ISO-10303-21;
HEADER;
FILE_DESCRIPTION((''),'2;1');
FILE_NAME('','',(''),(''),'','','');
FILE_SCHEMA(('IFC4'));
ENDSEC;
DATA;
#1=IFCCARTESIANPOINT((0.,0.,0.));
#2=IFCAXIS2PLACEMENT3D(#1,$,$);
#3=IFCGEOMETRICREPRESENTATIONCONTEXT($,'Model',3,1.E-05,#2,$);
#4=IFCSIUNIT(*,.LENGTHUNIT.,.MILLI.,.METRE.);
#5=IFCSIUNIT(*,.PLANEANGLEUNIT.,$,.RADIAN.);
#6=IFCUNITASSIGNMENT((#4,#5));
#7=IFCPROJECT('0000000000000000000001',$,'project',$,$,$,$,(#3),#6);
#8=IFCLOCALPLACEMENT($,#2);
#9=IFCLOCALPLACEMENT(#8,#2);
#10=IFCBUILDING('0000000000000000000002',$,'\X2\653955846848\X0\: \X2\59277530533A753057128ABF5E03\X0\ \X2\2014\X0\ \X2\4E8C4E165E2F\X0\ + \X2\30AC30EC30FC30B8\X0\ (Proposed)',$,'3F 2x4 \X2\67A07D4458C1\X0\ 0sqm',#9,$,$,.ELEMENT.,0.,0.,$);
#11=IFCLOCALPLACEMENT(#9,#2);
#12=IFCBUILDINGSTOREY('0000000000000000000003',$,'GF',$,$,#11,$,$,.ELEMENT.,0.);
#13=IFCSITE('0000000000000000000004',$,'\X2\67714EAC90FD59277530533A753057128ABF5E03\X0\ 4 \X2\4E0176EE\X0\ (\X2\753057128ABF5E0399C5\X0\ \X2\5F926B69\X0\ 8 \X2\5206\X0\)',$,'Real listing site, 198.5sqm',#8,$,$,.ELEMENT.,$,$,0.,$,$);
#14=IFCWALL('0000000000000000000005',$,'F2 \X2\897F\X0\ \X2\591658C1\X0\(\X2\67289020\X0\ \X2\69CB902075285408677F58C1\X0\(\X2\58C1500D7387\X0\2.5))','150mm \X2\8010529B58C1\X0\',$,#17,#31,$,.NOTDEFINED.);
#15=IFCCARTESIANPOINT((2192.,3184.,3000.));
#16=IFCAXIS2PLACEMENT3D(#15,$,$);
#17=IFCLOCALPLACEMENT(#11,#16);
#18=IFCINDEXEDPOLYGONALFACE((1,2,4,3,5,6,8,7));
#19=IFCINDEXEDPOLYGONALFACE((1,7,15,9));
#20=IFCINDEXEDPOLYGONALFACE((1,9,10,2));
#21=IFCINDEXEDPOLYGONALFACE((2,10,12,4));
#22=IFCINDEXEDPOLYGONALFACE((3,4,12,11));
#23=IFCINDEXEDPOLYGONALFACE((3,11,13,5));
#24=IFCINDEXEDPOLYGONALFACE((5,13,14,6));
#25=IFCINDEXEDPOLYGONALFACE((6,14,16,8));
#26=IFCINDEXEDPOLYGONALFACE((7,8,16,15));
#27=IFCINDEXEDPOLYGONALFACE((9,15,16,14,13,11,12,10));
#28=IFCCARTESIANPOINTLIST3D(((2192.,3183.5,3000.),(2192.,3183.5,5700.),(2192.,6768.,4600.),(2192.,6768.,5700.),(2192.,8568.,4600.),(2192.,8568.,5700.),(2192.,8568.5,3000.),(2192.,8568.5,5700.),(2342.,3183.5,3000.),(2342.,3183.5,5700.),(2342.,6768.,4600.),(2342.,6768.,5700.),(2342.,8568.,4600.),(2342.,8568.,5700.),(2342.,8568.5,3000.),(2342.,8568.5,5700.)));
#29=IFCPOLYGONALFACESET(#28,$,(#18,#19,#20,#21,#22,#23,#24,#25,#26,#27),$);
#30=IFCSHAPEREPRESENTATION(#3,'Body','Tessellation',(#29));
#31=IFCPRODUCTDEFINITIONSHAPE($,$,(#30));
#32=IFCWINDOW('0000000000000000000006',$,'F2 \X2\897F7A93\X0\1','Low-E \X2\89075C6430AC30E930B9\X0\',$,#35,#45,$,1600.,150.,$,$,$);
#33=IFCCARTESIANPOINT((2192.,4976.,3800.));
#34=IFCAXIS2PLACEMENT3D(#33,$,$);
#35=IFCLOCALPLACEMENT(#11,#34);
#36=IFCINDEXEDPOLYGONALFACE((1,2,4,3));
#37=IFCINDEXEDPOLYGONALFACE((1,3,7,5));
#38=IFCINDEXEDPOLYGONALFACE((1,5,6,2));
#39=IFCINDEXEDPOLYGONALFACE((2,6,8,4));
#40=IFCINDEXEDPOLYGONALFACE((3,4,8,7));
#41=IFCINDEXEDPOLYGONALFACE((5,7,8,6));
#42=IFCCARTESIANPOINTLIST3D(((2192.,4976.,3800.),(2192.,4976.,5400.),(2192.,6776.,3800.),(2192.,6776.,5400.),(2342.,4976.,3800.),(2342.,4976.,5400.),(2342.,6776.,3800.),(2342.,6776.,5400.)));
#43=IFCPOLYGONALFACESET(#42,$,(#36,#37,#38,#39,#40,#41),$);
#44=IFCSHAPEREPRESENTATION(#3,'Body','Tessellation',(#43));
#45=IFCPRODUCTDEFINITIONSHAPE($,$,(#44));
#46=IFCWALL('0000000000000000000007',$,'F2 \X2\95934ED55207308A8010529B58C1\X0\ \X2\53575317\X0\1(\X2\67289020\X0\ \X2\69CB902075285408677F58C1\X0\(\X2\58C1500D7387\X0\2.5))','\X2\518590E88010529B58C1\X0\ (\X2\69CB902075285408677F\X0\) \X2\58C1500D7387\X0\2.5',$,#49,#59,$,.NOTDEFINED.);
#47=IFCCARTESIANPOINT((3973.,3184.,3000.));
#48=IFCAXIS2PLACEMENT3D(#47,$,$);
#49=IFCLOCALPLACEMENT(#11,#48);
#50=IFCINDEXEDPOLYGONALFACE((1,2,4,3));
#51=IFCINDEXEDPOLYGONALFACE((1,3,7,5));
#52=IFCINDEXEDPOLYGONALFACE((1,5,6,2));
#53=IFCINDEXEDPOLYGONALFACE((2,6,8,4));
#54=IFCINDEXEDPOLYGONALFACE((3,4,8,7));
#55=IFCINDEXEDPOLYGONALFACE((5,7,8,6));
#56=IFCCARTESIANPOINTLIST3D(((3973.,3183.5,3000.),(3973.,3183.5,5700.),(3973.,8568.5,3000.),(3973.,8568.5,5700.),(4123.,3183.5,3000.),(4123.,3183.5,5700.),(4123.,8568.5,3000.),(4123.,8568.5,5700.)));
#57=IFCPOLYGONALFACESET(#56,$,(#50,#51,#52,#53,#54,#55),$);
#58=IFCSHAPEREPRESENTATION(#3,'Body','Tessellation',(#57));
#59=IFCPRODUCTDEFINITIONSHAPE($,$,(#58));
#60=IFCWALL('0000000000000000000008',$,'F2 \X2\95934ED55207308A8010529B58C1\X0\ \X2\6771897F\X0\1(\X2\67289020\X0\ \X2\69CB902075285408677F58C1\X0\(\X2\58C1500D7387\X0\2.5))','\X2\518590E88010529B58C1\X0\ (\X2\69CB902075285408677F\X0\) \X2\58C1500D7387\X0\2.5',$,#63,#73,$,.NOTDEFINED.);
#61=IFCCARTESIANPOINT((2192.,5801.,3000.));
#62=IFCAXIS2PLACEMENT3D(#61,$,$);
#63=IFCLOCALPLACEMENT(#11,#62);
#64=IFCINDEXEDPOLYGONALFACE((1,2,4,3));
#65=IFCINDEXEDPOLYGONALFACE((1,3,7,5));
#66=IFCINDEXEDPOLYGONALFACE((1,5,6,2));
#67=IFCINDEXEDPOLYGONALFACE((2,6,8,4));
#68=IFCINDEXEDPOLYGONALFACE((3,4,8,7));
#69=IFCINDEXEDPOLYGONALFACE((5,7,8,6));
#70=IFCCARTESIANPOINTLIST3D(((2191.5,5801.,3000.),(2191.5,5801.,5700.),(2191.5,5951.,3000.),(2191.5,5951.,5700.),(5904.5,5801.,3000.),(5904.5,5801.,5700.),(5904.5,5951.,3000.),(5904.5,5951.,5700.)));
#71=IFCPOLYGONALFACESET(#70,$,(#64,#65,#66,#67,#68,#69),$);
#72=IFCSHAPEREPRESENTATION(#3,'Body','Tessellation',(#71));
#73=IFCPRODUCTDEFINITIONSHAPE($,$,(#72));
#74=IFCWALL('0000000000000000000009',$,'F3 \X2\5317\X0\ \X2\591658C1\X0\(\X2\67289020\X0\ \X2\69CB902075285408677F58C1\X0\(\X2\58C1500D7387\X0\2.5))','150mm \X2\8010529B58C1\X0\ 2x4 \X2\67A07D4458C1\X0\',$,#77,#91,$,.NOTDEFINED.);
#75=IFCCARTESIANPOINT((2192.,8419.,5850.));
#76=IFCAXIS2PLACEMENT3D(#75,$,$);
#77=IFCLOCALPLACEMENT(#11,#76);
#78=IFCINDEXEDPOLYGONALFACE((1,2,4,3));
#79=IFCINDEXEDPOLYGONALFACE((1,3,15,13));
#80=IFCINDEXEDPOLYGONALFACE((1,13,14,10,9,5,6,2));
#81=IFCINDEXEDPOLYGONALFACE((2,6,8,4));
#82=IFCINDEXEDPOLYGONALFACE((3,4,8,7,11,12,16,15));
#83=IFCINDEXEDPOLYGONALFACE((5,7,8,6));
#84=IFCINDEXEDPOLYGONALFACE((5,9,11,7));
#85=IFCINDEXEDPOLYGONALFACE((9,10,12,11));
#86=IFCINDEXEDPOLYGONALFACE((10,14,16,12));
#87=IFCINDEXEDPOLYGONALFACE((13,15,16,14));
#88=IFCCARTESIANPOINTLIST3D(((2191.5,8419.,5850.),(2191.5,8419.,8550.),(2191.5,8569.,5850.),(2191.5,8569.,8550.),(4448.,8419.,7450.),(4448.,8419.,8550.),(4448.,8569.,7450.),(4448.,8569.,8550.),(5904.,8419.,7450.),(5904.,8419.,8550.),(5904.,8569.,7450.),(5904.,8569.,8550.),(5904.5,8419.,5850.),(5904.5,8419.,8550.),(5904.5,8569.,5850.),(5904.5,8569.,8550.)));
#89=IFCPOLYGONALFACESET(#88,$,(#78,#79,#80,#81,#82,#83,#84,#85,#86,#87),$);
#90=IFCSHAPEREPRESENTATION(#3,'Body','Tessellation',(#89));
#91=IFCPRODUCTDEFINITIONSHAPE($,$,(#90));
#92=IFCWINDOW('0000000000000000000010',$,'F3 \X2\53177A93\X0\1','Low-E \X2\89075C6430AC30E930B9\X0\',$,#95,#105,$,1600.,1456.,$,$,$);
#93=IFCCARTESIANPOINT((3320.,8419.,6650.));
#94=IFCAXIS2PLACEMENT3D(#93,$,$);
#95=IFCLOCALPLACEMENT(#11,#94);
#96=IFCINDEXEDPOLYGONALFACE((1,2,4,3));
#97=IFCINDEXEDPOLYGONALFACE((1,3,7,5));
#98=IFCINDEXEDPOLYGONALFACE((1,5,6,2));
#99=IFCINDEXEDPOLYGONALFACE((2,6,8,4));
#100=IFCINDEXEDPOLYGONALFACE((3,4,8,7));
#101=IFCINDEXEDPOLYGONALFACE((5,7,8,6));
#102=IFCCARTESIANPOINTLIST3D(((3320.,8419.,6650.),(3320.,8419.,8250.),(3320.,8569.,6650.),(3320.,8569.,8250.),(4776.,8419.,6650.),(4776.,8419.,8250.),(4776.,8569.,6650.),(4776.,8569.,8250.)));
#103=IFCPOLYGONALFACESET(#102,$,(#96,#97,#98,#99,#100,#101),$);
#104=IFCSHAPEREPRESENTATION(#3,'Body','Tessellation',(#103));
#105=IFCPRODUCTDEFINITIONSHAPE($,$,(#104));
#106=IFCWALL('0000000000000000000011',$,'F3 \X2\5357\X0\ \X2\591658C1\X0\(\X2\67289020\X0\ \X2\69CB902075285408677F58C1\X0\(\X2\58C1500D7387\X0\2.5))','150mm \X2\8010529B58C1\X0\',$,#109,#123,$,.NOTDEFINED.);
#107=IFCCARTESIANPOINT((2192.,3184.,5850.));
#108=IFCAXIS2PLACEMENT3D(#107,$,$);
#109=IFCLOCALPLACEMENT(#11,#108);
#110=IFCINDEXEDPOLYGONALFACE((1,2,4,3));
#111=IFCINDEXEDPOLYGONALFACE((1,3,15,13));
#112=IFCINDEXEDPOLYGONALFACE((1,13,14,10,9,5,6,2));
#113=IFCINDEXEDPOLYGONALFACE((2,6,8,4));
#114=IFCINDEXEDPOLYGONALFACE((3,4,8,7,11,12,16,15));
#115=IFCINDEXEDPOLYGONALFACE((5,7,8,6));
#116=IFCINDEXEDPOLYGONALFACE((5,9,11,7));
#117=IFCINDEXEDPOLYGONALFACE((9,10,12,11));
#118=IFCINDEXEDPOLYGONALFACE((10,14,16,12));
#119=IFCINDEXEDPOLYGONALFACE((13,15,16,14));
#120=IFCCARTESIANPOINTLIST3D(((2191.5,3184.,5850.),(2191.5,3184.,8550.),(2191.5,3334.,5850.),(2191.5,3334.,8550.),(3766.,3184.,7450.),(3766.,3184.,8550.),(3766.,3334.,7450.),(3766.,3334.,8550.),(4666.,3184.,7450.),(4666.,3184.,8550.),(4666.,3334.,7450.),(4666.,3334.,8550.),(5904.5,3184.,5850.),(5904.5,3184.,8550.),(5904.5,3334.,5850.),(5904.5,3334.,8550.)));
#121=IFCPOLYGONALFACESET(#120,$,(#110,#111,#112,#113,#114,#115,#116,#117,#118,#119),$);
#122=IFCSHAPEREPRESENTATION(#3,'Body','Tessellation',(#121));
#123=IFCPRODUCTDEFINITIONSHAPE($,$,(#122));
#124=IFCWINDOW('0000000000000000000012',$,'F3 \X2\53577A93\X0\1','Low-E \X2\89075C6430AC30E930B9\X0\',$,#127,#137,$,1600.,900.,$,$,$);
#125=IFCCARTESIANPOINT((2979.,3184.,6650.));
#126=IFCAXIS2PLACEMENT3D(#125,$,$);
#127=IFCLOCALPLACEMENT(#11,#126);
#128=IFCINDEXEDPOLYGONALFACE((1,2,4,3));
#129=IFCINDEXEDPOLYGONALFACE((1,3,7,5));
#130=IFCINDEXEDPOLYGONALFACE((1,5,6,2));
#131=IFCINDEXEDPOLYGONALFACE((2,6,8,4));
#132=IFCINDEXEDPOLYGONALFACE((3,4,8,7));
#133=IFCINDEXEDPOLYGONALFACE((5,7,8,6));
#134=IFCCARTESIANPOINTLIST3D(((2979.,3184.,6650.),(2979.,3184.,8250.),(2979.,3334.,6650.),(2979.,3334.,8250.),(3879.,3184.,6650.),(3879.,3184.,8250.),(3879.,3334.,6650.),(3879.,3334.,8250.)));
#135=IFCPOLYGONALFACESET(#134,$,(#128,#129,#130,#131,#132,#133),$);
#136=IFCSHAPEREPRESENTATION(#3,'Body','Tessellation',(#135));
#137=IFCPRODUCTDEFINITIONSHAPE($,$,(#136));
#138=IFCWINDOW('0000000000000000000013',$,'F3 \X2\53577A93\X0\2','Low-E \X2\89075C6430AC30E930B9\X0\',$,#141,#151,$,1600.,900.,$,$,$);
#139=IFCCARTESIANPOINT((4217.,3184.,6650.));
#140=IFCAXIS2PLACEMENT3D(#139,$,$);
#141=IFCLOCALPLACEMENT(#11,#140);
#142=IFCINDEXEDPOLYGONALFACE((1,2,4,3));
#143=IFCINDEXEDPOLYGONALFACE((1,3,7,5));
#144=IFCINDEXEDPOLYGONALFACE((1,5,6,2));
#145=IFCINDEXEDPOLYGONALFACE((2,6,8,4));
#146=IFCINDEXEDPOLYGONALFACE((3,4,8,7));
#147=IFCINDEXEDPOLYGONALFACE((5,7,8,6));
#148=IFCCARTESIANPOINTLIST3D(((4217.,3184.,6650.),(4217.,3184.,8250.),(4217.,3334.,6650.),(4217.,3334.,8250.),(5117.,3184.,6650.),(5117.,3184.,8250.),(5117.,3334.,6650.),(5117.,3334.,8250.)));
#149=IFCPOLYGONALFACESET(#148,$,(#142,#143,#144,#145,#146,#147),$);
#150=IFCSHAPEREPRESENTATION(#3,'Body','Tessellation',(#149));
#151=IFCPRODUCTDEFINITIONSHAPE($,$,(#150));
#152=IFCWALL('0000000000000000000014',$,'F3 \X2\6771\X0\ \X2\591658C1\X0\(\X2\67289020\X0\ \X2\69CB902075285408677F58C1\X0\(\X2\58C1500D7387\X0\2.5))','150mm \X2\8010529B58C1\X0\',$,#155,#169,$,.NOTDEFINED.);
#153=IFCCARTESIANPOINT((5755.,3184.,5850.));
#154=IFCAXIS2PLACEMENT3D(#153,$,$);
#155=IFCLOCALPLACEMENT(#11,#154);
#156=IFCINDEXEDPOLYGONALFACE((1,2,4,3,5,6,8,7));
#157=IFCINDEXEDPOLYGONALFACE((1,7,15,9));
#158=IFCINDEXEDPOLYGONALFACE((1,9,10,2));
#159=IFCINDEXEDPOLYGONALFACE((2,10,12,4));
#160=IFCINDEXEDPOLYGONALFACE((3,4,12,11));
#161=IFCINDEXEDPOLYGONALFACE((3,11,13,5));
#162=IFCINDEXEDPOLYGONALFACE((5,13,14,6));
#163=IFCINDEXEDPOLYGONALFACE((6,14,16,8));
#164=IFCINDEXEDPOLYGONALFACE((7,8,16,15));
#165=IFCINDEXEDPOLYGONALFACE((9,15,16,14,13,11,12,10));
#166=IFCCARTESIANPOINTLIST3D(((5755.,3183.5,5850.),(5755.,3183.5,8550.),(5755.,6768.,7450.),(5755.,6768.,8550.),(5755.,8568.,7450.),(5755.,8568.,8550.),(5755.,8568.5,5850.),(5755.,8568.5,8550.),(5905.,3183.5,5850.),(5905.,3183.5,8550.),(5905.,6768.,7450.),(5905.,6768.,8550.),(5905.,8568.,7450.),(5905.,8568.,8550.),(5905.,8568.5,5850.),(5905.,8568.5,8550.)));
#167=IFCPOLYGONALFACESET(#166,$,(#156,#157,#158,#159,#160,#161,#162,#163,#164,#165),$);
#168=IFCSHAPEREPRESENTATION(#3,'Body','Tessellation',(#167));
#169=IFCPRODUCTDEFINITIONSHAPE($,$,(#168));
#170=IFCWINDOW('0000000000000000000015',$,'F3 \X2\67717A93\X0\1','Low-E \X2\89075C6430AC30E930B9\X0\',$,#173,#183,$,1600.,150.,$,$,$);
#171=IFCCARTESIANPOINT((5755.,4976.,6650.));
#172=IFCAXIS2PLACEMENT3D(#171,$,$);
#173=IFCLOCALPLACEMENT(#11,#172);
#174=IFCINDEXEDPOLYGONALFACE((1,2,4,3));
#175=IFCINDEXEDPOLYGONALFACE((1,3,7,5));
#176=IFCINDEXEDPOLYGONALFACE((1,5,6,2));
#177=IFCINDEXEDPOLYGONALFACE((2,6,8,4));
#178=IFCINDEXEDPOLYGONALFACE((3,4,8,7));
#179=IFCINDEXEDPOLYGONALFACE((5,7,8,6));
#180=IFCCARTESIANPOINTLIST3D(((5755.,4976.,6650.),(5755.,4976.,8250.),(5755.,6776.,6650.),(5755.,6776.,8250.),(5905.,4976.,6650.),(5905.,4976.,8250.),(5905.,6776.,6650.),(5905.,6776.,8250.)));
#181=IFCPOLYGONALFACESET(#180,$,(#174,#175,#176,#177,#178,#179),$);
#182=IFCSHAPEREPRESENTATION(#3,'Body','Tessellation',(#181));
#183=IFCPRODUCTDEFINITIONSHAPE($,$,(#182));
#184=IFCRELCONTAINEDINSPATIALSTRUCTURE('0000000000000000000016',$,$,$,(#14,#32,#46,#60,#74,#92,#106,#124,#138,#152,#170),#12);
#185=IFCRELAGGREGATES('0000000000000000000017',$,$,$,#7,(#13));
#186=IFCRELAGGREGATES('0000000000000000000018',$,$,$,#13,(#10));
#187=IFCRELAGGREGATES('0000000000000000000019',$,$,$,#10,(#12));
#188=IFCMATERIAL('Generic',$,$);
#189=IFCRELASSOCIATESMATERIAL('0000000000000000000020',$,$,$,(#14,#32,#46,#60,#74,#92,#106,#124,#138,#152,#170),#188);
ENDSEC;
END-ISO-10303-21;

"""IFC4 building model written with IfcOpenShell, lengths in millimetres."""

from ifc_helpers import new_model, si_unit, frame, frame_2d, origin, place, context, project, spatial, rectangle, extrude, material, element, fill, save


model = new_model("IFC4")

# Units and contexts
model_context = context("Model", 3, precision=1e-05, world=origin())
ifc_project = project(units=[si_unit("LENGTHUNIT", "METRE", prefix="MILLI"), si_unit("PLANEANGLEUNIT", "RADIAN")], contexts=[model_context])

# Site, building, storey
site_placement = place(None, origin())
site = spatial("IfcSite", under=ifc_project, at=site_placement, Name="東京都大田区田園調布 4 丁目 (田園調布駅 徒歩 8 分)", ObjectType="Real listing site, 198.5sqm", CompositionType="ELEMENT", RefElevation=0.0)
building_placement = place(site_placement, origin())
building = spatial("IfcBuilding", under=site, at=building_placement, Name="改善案: 大田区田園調布 — 二世帯 + ガレージ (Proposed)", ObjectType="3F 2x4 枠組壁 0sqm", CompositionType="ELEMENT", ElevationOfRefHeight=0.0, ElevationOfTerrain=0.0)
storey_placement = place(building_placement, origin())
storey = spatial("IfcBuildingStorey", under=building, at=storey_placement, Name="GF", CompositionType="ELEMENT", Elevation=0.0)

# Shared definitions
ifc_material_1 = material(Name="Generic")

# Wall, opening, window
wall_1_placement = place(storey_placement, frame((2192.0, 3184.0, 3000.0)))
wall_1 = element("IfcWall", 1, at=wall_1_placement, inside=storey, material=ifc_material_1, Name="F2 西 外壁(木造 構造用合板壁(壁倍率2.5))", Description="150mm 耐力壁", PredefinedType="NOTDEFINED", context=model_context, shape_type="SweptSolid", body=[
    extrude(rectangle(XDim=150.0, YDim=5385.0, at=frame_2d((75.0, 2692.0))), frame((2192.0, 3184.0, 3000.0)), (0.0, 0.0, 1.0), 2700.0),
])
opening_1_placement = place(storey_placement, frame((2192.0, 4976.0, 3800.0)))
opening_1 = element("IfcOpeningElement", 2, at=opening_1_placement, cuts=wall_1, PredefinedType="NOTDEFINED", context=model_context, shape_type="SweptSolid", body=[
    extrude(rectangle(XDim=150.0, YDim=1800.0, at=frame_2d((75.0, 900.0))), frame((2192.0, 4976.0, 3800.0)), (0.0, 0.0, 1.0), 1600.0),
])
window_1_placement = place(storey_placement, frame((2192.0, 4976.0, 3800.0)))
window_1 = element("IfcWindow", 3, at=window_1_placement, inside=storey, material=ifc_material_1, Name="F2 西窓1", Description="Low-E 複層ガラス", OverallHeight=1600.0, OverallWidth=150.0, context=model_context, shape_type="SweptSolid", body=[
    extrude(rectangle(XDim=150.0, YDim=1800.0, at=frame_2d((75.0, 900.0))), frame((2192.0, 4976.0, 3800.0)), (0.0, 0.0, 1.0), 1600.0),
])
fill(opening_1, window_1)

# Walls
wall_2_placement = place(storey_placement, frame((3973.0, 3184.0, 3000.0)))
element("IfcWall", 4, at=wall_2_placement, inside=storey, material=ifc_material_1, Name="F2 間仕切り耐力壁 南北1(木造 構造用合板壁(壁倍率2.5))", Description="内部耐力壁 (構造用合板) 壁倍率2.5", PredefinedType="NOTDEFINED", context=model_context, shape_type="SweptSolid", body=[
    extrude(rectangle(XDim=150.0, YDim=5385.0, at=frame_2d((75.0, 2692.0))), frame((3973.0, 3184.0, 3000.0)), (0.0, 0.0, 1.0), 2700.0),
])
wall_3_placement = place(storey_placement, frame((2192.0, 5801.0, 3000.0)))
element("IfcWall", 5, at=wall_3_placement, inside=storey, material=ifc_material_1, Name="F2 間仕切り耐力壁 東西1(木造 構造用合板壁(壁倍率2.5))", Description="内部耐力壁 (構造用合板) 壁倍率2.5", PredefinedType="NOTDEFINED", context=model_context, shape_type="SweptSolid", body=[
    extrude(rectangle(XDim=3713.0, YDim=150.0, at=frame_2d((1856.0, 75.0))), frame((2192.0, 5801.0, 3000.0)), (0.0, 0.0, 1.0), 2700.0),
])

# Wall, opening, window
wall_4_placement = place(storey_placement, frame((2192.0, 8419.0, 5850.0)))
wall_4 = element("IfcWall", 6, at=wall_4_placement, inside=storey, material=ifc_material_1, Name="F3 北 外壁(木造 構造用合板壁(壁倍率2.5))", Description="150mm 耐力壁 2x4 枠組壁", PredefinedType="NOTDEFINED", context=model_context, shape_type="SweptSolid", body=[
    extrude(rectangle(XDim=3713.0, YDim=150.0, at=frame_2d((1856.0, 75.0))), frame((2192.0, 8419.0, 5850.0)), (0.0, 0.0, 1.0), 2700.0),
])
opening_2_placement = place(storey_placement, frame((3320.0, 8419.0, 6650.0)))
opening_2 = element("IfcOpeningElement", 7, at=opening_2_placement, cuts=wall_4, PredefinedType="NOTDEFINED", context=model_context, shape_type="SweptSolid", body=[
    extrude(rectangle(XDim=1456.0, YDim=150.0, at=frame_2d((728.0, 75.0))), frame((3320.0, 8419.0, 6650.0)), (0.0, 0.0, 1.0), 1600.0),
])
window_2_placement = place(storey_placement, frame((3320.0, 8419.0, 6650.0)))
window_2 = element("IfcWindow", 8, at=window_2_placement, inside=storey, material=ifc_material_1, Name="F3 北窓1", Description="Low-E 複層ガラス", OverallHeight=1600.0, OverallWidth=1456.0, context=model_context, shape_type="SweptSolid", body=[
    extrude(rectangle(XDim=1456.0, YDim=150.0, at=frame_2d((728.0, 75.0))), frame((3320.0, 8419.0, 6650.0)), (0.0, 0.0, 1.0), 1600.0),
])
fill(opening_2, window_2)

# Wall, openings, windows
wall_5_placement = place(storey_placement, frame((2192.0, 3184.0, 5850.0)))
wall_5 = element("IfcWall", 9, at=wall_5_placement, inside=storey, material=ifc_material_1, Name="F3 南 外壁(木造 構造用合板壁(壁倍率2.5))", Description="150mm 耐力壁", PredefinedType="NOTDEFINED", context=model_context, shape_type="SweptSolid", body=[
    extrude(rectangle(XDim=3713.0, YDim=150.0, at=frame_2d((1856.0, 75.0))), frame((2192.0, 3184.0, 5850.0)), (0.0, 0.0, 1.0), 2700.0),
])
opening_3_placement = place(storey_placement, frame((2979.0, 3184.0, 6650.0)))
opening_3 = element("IfcOpeningElement", 10, at=opening_3_placement, cuts=wall_5, PredefinedType="NOTDEFINED", context=model_context, shape_type="SweptSolid", body=[
    extrude(rectangle(XDim=900.0, YDim=150.0, at=frame_2d((450.0, 75.0))), frame((2979.0, 3184.0, 6650.0)), (0.0, 0.0, 1.0), 1600.0),
])
opening_4_placement = place(storey_placement, frame((4217.0, 3184.0, 6650.0)))
opening_4 = element("IfcOpeningElement", 11, at=opening_4_placement, cuts=wall_5, PredefinedType="NOTDEFINED", context=model_context, shape_type="SweptSolid", body=[
    extrude(rectangle(XDim=900.0, YDim=150.0, at=frame_2d((450.0, 75.0))), frame((4217.0, 3184.0, 6650.0)), (0.0, 0.0, 1.0), 1600.0),
])
window_3_placement = place(storey_placement, frame((2979.0, 3184.0, 6650.0)))
window_3 = element("IfcWindow", 12, at=window_3_placement, inside=storey, material=ifc_material_1, Name="F3 南窓1", Description="Low-E 複層ガラス", OverallHeight=1600.0, OverallWidth=900.0, context=model_context, shape_type="SweptSolid", body=[
    extrude(rectangle(XDim=900.0, YDim=150.0, at=frame_2d((450.0, 75.0))), frame((2979.0, 3184.0, 6650.0)), (0.0, 0.0, 1.0), 1600.0),
])
fill(opening_3, window_3)
window_4_placement = place(storey_placement, frame((4217.0, 3184.0, 6650.0)))
window_4 = element("IfcWindow", 13, at=window_4_placement, inside=storey, material=ifc_material_1, Name="F3 南窓2", Description="Low-E 複層ガラス", OverallHeight=1600.0, OverallWidth=900.0, context=model_context, shape_type="SweptSolid", body=[
    extrude(rectangle(XDim=900.0, YDim=150.0, at=frame_2d((450.0, 75.0))), frame((4217.0, 3184.0, 6650.0)), (0.0, 0.0, 1.0), 1600.0),
])
fill(opening_4, window_4)

# Wall, opening, window
wall_6_placement = place(storey_placement, frame((5755.0, 3184.0, 5850.0)))
wall_6 = element("IfcWall", 14, at=wall_6_placement, inside=storey, material=ifc_material_1, Name="F3 東 外壁(木造 構造用合板壁(壁倍率2.5))", Description="150mm 耐力壁", PredefinedType="NOTDEFINED", context=model_context, shape_type="SweptSolid", body=[
    extrude(rectangle(XDim=150.0, YDim=5385.0, at=frame_2d((75.0, 2692.0))), frame((5755.0, 3184.0, 5850.0)), (0.0, 0.0, 1.0), 2700.0),
])
opening_5_placement = place(storey_placement, frame((5755.0, 4976.0, 6650.0)))
opening_5 = element("IfcOpeningElement", 15, at=opening_5_placement, cuts=wall_6, PredefinedType="NOTDEFINED", context=model_context, shape_type="SweptSolid", body=[
    extrude(rectangle(XDim=150.0, YDim=1800.0, at=frame_2d((75.0, 900.0))), frame((5755.0, 4976.0, 6650.0)), (0.0, 0.0, 1.0), 1600.0),
])
window_5_placement = place(storey_placement, frame((5755.0, 4976.0, 6650.0)))
window_5 = element("IfcWindow", 16, at=window_5_placement, inside=storey, material=ifc_material_1, Name="F3 東窓1", Description="Low-E 複層ガラス", OverallHeight=1600.0, OverallWidth=150.0, context=model_context, shape_type="SweptSolid", body=[
    extrude(rectangle(XDim=150.0, YDim=1800.0, at=frame_2d((75.0, 900.0))), frame((5755.0, 4976.0, 6650.0)), (0.0, 0.0, 1.0), 1600.0),
])
fill(opening_5, window_5)

save(model, "model.ifc")
